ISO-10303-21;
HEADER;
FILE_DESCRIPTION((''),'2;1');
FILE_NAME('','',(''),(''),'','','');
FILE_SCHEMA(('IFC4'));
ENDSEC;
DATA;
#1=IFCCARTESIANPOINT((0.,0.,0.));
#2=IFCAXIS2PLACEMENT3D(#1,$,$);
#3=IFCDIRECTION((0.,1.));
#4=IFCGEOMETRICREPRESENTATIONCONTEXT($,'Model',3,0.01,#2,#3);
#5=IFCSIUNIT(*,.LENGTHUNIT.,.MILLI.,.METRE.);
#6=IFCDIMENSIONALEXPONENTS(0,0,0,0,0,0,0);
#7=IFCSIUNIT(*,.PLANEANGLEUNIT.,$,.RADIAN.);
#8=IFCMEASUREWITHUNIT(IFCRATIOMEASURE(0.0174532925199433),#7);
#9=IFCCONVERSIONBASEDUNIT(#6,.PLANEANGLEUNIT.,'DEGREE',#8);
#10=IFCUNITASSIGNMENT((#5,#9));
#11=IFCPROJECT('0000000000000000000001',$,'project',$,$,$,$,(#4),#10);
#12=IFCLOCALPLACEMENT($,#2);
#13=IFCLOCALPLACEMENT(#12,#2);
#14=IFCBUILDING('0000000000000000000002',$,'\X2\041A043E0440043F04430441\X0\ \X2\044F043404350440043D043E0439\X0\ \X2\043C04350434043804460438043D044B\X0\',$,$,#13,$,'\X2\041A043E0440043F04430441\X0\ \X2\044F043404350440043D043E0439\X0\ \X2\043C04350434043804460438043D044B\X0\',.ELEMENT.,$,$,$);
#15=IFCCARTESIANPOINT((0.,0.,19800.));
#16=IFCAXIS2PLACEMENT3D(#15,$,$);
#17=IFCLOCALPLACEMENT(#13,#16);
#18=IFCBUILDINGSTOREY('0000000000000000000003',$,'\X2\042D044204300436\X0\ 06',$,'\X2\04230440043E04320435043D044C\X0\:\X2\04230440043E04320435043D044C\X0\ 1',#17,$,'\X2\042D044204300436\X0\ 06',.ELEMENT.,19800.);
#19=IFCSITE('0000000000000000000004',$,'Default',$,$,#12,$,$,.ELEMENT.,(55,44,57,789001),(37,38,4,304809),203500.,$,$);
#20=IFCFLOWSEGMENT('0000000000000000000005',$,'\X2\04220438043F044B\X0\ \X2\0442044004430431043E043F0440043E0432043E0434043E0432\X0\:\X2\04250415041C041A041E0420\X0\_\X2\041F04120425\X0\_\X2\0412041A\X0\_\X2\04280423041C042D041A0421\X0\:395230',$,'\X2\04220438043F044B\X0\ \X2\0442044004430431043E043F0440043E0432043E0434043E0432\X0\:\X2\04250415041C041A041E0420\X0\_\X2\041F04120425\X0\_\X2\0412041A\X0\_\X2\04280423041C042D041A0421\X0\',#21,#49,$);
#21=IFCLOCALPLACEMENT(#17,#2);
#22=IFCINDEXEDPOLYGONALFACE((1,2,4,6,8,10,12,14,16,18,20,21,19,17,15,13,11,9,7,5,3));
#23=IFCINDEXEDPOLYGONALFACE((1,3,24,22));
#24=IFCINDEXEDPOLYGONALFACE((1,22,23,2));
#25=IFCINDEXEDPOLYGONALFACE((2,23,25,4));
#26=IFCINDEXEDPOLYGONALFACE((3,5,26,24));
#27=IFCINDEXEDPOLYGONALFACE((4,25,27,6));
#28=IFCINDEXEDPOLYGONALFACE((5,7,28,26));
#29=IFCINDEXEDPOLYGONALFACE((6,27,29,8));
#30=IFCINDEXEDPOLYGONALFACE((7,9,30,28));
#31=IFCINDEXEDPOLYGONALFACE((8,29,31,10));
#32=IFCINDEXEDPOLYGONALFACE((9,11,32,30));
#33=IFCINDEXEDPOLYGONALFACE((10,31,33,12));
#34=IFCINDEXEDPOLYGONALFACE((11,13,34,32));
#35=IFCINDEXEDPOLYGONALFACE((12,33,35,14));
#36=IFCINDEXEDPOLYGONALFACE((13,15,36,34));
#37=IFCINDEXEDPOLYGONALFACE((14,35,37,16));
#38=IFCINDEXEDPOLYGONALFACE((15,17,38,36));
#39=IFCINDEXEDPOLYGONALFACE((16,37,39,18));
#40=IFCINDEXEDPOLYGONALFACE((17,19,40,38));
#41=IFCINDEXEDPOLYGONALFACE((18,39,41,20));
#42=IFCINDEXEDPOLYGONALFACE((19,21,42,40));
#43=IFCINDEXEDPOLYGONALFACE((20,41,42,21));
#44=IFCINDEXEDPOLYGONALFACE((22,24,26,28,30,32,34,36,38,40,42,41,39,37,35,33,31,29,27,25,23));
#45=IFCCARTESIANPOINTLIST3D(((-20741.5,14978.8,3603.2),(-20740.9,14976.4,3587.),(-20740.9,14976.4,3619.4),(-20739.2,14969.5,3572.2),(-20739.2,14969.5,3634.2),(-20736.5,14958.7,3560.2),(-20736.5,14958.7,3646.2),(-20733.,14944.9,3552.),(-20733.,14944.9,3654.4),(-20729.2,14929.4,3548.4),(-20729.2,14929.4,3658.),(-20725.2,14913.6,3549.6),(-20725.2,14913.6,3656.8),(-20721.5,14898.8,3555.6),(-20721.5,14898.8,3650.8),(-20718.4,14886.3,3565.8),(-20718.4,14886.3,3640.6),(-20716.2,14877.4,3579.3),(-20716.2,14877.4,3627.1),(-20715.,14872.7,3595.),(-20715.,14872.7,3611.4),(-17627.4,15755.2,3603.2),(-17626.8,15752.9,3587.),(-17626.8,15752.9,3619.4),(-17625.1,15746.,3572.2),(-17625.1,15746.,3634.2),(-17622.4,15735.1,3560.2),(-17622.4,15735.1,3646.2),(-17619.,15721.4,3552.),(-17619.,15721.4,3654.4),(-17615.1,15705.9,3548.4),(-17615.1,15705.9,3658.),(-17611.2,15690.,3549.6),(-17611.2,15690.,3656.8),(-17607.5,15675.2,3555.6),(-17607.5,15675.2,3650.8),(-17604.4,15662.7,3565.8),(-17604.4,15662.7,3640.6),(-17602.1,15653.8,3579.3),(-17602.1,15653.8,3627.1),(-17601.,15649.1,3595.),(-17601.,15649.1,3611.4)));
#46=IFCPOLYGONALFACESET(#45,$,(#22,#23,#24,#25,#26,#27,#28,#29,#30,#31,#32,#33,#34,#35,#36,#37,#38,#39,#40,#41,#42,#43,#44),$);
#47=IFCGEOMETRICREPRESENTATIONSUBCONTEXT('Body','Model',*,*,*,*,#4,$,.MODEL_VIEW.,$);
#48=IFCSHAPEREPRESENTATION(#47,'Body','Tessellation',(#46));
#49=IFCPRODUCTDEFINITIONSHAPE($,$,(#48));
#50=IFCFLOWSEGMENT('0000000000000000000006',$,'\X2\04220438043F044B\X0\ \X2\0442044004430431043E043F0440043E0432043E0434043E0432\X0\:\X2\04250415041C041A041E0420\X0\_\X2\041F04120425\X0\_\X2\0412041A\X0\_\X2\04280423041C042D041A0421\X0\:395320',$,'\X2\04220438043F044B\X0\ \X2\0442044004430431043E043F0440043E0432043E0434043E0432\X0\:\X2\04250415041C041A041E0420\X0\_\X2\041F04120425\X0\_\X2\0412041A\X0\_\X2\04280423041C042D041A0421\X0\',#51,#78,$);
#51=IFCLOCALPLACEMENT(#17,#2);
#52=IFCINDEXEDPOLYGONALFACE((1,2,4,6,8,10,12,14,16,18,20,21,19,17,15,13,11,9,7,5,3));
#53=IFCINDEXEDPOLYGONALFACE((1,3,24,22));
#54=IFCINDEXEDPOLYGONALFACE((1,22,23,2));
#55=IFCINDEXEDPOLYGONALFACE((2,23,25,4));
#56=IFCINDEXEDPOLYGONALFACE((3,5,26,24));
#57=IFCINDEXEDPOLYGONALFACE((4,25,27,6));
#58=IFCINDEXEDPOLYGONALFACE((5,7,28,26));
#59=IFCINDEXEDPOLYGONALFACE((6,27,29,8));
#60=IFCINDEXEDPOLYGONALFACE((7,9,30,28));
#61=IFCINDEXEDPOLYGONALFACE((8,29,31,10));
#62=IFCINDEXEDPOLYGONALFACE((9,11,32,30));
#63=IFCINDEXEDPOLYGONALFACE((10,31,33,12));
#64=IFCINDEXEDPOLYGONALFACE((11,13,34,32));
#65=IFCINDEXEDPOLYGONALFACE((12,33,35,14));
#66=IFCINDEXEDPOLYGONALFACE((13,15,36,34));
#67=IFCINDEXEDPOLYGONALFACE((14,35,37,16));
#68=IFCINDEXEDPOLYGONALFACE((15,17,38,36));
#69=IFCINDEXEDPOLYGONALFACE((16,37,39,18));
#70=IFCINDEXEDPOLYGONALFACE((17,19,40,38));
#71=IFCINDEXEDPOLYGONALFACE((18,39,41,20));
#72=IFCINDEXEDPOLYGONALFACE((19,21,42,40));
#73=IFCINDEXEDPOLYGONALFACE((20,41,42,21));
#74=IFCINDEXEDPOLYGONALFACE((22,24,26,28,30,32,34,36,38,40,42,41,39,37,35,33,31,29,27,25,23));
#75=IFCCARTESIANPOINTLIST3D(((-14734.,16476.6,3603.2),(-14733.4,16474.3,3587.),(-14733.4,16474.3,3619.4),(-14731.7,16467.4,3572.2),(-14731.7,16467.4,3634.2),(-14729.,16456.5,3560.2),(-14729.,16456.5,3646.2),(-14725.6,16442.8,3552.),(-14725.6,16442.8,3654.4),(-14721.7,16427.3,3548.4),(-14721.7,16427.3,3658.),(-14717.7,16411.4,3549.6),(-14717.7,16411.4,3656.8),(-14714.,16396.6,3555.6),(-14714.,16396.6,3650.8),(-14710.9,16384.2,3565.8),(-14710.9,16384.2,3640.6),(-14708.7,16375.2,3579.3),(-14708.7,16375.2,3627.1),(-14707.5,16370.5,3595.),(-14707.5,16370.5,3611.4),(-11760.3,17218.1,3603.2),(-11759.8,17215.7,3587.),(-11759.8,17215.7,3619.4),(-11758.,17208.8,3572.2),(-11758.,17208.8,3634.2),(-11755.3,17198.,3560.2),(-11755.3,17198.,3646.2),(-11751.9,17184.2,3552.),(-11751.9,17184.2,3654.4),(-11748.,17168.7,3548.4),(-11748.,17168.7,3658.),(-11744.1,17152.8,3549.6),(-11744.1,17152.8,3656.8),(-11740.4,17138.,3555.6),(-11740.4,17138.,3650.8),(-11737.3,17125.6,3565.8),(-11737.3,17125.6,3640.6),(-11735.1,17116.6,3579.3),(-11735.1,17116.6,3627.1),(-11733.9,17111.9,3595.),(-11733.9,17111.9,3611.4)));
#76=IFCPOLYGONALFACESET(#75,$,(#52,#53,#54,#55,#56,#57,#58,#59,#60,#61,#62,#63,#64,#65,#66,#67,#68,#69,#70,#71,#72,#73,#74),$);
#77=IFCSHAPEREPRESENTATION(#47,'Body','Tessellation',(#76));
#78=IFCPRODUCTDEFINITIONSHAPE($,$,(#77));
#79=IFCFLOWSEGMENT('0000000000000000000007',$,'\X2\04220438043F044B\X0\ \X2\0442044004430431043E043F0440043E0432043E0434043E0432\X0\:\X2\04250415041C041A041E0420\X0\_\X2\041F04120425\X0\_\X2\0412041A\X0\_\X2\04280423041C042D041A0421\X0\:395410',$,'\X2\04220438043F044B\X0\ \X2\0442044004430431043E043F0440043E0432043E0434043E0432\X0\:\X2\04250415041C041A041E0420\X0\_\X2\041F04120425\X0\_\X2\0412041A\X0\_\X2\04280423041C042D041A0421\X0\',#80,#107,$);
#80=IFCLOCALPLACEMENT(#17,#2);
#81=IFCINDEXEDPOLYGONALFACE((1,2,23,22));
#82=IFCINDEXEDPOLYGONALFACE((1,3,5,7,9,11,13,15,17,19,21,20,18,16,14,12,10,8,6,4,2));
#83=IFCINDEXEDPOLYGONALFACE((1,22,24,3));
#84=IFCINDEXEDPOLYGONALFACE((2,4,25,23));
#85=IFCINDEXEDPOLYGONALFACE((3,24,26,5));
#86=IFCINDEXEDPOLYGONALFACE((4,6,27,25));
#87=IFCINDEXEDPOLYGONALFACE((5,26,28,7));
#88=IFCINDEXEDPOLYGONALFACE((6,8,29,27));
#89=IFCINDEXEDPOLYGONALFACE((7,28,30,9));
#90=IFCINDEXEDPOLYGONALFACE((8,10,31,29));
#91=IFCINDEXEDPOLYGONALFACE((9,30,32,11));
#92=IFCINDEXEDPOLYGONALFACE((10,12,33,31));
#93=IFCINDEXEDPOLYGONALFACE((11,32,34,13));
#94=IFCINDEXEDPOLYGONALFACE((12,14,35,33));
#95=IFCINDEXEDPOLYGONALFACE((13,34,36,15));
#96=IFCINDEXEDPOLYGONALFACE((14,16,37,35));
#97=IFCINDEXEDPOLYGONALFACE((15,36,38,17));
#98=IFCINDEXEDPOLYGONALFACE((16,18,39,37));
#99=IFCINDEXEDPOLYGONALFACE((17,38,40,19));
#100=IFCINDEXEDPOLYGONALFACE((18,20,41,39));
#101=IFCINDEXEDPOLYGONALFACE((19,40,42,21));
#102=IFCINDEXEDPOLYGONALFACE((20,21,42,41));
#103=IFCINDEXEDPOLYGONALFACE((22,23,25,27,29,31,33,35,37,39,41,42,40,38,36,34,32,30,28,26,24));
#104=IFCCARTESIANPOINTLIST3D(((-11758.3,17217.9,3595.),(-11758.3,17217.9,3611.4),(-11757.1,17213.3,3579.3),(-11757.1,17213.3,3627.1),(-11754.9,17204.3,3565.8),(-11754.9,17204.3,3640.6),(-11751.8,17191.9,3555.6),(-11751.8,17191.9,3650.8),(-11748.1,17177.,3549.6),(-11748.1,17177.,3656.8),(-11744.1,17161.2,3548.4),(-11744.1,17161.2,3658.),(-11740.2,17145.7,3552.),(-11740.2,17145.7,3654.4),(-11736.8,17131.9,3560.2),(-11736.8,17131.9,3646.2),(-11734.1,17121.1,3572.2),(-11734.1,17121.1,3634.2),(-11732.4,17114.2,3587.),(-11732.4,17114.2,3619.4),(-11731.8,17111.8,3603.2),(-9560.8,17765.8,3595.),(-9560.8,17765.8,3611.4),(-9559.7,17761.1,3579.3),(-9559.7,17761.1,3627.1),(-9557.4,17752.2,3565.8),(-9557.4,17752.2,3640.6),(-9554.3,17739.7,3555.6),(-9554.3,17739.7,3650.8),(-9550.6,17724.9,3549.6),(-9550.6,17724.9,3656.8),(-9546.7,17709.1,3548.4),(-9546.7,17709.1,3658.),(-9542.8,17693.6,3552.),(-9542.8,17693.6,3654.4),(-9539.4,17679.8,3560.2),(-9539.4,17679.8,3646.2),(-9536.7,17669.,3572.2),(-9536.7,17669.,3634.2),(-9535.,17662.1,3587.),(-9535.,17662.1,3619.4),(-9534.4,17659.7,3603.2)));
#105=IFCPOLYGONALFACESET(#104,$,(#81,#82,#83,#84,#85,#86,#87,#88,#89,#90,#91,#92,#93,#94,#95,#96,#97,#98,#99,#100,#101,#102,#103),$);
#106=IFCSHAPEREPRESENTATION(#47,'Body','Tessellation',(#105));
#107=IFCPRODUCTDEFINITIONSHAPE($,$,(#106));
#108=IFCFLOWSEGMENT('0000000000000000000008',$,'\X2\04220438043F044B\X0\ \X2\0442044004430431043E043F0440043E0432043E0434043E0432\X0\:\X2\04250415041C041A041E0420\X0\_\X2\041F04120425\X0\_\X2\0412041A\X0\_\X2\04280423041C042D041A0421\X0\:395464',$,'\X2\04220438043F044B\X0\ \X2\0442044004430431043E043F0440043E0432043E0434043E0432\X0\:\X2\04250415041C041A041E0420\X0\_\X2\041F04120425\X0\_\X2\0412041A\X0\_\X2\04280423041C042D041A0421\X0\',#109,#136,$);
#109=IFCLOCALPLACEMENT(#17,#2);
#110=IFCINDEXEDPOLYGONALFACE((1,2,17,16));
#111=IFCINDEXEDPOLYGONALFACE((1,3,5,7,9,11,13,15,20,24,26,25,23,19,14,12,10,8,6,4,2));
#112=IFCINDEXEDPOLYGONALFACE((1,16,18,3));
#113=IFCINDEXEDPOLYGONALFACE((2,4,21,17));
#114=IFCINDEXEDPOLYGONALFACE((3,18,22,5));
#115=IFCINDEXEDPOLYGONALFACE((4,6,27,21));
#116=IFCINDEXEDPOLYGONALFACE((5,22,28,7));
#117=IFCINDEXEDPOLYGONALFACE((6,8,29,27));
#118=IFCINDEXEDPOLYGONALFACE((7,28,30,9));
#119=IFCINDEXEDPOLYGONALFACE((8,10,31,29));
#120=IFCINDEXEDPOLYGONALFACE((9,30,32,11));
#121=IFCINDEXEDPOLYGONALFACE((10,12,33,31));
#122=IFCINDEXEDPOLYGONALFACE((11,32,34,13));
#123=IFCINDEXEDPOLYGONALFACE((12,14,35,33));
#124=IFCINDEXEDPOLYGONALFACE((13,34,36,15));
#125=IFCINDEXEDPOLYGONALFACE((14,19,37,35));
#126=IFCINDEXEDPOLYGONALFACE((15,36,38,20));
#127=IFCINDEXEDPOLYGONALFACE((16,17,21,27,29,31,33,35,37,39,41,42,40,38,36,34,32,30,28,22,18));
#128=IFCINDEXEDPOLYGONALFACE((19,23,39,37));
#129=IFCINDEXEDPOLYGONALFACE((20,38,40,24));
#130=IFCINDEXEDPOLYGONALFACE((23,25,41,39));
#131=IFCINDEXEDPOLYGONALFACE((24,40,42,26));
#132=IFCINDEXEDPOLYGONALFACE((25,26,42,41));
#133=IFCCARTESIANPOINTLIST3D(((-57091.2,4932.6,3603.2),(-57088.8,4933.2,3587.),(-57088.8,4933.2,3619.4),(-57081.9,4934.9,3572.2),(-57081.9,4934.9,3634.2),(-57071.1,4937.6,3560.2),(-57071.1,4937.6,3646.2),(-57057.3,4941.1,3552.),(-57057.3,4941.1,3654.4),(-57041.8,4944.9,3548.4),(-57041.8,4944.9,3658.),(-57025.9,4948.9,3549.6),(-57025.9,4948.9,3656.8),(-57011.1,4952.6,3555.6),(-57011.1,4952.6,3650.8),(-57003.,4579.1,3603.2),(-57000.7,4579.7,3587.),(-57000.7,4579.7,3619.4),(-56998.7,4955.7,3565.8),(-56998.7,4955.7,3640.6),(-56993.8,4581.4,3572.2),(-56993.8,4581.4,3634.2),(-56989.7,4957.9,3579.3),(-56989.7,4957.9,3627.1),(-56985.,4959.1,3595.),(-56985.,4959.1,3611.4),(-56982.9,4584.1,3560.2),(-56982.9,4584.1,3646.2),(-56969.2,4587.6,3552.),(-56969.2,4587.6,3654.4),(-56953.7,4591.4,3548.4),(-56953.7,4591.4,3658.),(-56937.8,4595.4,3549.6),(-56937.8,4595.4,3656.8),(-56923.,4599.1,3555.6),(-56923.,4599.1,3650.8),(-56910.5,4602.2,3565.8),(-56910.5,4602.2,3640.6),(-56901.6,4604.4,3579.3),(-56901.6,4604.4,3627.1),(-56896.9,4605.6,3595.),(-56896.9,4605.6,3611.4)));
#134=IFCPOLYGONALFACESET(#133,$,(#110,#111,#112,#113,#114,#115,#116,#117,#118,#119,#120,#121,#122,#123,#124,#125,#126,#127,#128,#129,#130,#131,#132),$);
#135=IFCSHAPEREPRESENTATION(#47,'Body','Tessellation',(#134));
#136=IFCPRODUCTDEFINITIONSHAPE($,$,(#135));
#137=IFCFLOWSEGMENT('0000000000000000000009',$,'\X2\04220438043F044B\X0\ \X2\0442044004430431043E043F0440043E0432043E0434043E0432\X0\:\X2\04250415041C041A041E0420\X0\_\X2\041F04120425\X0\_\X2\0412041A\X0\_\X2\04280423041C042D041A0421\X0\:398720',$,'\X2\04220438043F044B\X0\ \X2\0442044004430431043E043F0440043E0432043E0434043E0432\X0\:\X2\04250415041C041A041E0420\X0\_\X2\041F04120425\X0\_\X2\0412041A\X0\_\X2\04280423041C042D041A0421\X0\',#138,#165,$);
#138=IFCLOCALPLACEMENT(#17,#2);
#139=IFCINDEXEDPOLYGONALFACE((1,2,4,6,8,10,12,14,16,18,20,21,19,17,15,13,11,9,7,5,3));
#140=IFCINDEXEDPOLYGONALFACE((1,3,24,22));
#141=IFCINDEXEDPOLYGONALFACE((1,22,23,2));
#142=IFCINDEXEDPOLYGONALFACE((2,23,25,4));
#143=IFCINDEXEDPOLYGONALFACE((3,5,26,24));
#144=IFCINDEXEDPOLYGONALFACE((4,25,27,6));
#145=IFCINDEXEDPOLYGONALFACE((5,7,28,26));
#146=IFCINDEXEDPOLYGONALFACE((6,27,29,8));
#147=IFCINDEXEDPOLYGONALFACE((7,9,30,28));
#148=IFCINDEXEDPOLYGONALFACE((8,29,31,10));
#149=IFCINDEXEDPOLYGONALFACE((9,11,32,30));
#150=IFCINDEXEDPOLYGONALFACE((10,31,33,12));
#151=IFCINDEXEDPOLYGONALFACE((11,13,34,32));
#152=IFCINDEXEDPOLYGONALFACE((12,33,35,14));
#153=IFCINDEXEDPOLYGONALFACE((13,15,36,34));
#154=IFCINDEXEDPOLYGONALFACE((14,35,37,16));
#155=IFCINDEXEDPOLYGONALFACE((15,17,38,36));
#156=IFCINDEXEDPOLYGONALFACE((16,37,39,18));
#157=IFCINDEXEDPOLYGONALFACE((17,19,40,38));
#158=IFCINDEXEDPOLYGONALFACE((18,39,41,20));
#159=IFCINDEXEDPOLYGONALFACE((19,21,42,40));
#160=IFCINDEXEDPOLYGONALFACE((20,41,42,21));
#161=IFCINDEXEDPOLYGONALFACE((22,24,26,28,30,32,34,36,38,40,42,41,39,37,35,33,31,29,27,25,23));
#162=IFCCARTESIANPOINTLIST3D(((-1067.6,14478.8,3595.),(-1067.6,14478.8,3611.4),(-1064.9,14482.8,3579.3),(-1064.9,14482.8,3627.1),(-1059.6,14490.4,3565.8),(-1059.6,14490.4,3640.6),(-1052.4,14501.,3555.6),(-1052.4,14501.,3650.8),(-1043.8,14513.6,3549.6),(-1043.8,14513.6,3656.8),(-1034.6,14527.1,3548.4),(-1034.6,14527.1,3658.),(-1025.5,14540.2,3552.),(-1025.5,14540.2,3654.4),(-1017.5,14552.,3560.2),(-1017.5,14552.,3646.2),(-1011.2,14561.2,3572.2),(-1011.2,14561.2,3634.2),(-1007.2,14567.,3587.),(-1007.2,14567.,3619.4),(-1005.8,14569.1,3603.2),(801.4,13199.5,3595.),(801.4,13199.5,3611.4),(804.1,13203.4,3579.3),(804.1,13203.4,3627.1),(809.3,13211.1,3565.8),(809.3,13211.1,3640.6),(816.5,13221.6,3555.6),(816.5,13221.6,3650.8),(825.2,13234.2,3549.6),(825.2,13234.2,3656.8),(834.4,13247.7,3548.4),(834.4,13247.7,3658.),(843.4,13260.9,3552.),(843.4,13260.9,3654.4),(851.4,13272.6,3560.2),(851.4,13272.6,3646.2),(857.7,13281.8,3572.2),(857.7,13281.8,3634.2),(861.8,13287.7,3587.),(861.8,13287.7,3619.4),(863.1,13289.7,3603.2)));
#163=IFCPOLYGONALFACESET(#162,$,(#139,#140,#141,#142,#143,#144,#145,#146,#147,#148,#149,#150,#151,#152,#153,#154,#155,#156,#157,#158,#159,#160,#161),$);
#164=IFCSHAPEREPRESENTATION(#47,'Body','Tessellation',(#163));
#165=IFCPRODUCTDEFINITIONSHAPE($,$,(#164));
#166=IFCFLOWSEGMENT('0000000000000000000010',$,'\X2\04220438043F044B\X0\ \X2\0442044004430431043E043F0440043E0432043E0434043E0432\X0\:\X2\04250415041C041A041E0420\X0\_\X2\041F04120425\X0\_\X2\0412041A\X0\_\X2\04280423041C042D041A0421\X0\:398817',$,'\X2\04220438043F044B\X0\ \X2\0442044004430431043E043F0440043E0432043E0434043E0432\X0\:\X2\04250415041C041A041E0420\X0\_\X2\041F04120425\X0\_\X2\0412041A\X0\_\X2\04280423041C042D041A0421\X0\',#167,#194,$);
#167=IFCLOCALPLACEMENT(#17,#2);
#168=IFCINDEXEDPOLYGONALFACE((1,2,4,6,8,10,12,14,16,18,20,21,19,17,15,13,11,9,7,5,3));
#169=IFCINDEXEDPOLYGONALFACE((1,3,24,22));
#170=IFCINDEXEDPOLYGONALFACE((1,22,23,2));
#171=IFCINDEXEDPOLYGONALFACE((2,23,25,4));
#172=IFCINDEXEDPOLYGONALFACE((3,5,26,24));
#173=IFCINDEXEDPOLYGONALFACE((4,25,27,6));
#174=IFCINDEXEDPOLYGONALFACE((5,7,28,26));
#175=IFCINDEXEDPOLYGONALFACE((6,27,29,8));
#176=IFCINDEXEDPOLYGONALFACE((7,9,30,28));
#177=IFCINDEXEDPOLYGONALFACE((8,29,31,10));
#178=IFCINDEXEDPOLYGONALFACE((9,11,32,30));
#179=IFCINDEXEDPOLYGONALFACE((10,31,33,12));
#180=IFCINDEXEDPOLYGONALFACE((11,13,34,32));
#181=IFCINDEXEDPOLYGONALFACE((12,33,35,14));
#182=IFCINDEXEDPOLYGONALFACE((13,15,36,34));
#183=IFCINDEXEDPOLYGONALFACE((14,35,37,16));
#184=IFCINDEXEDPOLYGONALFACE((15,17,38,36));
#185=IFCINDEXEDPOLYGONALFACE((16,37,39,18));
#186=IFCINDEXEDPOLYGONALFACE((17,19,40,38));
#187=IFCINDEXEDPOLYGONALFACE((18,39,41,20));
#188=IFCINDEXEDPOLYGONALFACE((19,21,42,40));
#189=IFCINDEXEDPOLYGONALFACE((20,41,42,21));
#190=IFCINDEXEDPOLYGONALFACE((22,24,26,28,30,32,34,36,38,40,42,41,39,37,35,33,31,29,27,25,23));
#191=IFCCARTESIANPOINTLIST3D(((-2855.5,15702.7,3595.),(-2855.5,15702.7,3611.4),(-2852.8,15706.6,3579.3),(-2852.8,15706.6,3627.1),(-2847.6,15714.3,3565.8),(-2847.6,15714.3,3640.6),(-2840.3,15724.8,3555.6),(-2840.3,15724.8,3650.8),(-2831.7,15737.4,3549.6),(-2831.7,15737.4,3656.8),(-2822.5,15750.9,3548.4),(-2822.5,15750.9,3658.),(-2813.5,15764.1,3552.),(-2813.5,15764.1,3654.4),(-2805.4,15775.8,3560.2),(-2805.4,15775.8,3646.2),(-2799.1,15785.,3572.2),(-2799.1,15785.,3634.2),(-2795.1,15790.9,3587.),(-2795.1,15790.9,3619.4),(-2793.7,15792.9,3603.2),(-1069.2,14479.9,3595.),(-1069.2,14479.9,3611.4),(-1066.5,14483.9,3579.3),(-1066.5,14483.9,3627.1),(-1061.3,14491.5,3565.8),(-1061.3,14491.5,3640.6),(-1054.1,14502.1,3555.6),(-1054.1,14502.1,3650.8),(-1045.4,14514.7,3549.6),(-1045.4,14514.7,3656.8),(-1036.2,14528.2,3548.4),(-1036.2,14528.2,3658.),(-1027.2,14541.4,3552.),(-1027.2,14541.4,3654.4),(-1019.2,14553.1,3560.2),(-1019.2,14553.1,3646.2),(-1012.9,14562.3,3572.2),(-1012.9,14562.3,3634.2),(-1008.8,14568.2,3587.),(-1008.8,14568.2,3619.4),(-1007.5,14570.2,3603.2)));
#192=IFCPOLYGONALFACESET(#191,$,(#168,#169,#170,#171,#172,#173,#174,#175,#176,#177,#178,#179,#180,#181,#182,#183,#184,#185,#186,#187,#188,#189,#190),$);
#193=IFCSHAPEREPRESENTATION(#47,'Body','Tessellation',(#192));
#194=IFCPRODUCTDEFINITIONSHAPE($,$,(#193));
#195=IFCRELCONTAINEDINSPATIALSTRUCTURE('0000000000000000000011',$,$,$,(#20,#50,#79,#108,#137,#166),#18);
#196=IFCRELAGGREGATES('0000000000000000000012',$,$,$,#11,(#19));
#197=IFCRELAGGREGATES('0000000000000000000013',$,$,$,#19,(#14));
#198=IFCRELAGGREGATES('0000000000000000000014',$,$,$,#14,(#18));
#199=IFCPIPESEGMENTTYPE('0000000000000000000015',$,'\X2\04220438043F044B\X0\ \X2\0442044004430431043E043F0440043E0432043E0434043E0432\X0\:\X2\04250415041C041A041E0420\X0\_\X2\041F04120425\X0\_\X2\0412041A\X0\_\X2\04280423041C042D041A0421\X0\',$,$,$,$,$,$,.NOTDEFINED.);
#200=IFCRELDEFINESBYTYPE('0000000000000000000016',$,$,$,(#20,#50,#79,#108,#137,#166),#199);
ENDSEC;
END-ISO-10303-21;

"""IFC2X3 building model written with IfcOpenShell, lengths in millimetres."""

from ifc_helpers import new_model, entity, si_unit, converted_unit, direction, frame, frame_2d, origin, origin_2d_with_axis, place, context, subcontext, project, spatial, circle, extrude, type_object, element, save


model = new_model("IFC2X3")

# Units and contexts
model_context = context("Model", 3, precision=0.01, world=origin(), true_north=direction((0.0, 1.0)))
body_context = subcontext(model_context, "Body", "Model", "MODEL_VIEW")
ifc_project = project(units=[si_unit("LENGTHUNIT", "METRE", prefix="MILLI"), converted_unit("PLANEANGLEUNIT", "DEGREE", entity("IfcRatioMeasure", 0.0174532925199433), si_unit("PLANEANGLEUNIT", "RADIAN"), dimensions=[0, 0, 0, 0, 0, 0, 0])], contexts=[model_context])

# Site, building, storey
site_placement = place(None, frame((0.0, 0.0, 0.0)))
site = spatial("IfcSite", under=ifc_project, at=site_placement, Name="Default", CompositionType="ELEMENT", RefLatitude=(55, 44, 57, 789001), RefLongitude=(37, 38, 4, 304809), RefElevation=203500.0)
building_placement = place(site_placement, origin())
building = spatial("IfcBuilding", under=site, at=building_placement, Name="Корпус ядерной медицины", LongName="Корпус ядерной медицины", CompositionType="ELEMENT")
storey_placement = place(building_placement, frame((0.0, 0.0, 19800.0)))
storey = spatial("IfcBuildingStorey", under=building, at=storey_placement, Name="Этаж 06", ObjectType="Уровень:Уровень 1", LongName="Этаж 06", CompositionType="ELEMENT", Elevation=19800.0)

# Flow segments
pipe_segment_type = type_object("IfcPipeSegmentType", Name="Типы трубопроводов:ХЕМКОР_ПВХ_ВК_ШУМЭКС", PredefinedType="NOTDEFINED")
flow_segment_1_placement = place(storey_placement, frame((-20743.1, 14870.5, 3546.6)))
element("IfcFlowSegment", 1, at=flow_segment_1_placement, inside=storey, type_object=pipe_segment_type, Name="Типы трубопроводов:ХЕМКОР_ПВХ_ВК_ШУМЭКС:395230", ObjectType="Типы трубопроводов:ХЕМКОР_ПВХ_ВК_ШУМЭКС", context=body_context, shape_type="SweptSolid", body=[
    extrude(circle(Radius=55.0, at=origin_2d_with_axis()), frame((14.9, 55.0, 56.6), z_axis=(0.970296, 0.241922, 0.0), x_axis=(-0.241922, 0.970296, 0.0)), (0.0, 0.0, 1.0), 3209.4),
])
flow_segment_2_placement = place(storey_placement, frame((-14735.6, 16368.3, 3546.6)))
element("IfcFlowSegment", 2, at=flow_segment_2_placement, inside=storey, type_object=pipe_segment_type, Name="Типы трубопроводов:ХЕМКОР_ПВХ_ВК_ШУМЭКС:395320", ObjectType="Типы трубопроводов:ХЕМКОР_ПВХ_ВК_ШУМЭКС", context=body_context, shape_type="SweptSolid", body=[
    extrude(circle(Radius=55.0, at=frame_2d((0.0, 0.0), x_axis=(1.0, 0.0))), frame((14.9, 55.0, 56.6), z_axis=(0.970296, 0.241922, 0.0), x_axis=(-0.241922, 0.970296, 0.0)), (0.0, 0.0, 1.0), 3064.7),
])
flow_segment_3_placement = place(storey_placement, frame((-11760.0, 17110.2, 3546.6)))
element("IfcFlowSegment", 3, at=flow_segment_3_placement, inside=storey, type_object=pipe_segment_type, Name="Типы трубопроводов:ХЕМКОР_ПВХ_ВК_ШУМЭКС:395410", ObjectType="Типы трубопроводов:ХЕМКОР_ПВХ_ВК_ШУМЭКС", context=body_context, shape_type="SweptSolid", body=[
    extrude(circle(Radius=55.0, at=origin_2d_with_axis()), frame((14.9, 55.0, 56.6), z_axis=(0.970296, 0.241922, 0.0), x_axis=(0.241922, -0.970296, 0.0)), (0.0, 0.0, 1.0), 2264.7),
])
flow_segment_4_placement = place(storey_placement, frame((-57092.8, 4577.5, 3546.6)))
element("IfcFlowSegment", 4, at=flow_segment_4_placement, inside=storey, type_object=pipe_segment_type, Name="Типы трубопроводов:ХЕМКОР_ПВХ_ВК_ШУМЭКС:395464", ObjectType="Типы трубопроводов:ХЕМКОР_ПВХ_ВК_ШУМЭКС", context=body_context, shape_type="SweptSolid", body=[
    extrude(circle(Radius=55.0, at=origin_2d_with_axis()), frame((55.0, 368.4, 56.6), z_axis=(0.241922, -0.970296, 0.0), x_axis=(-0.970296, -0.241922, 0.0)), (0.0, 0.0, 1.0), 364.3),
])
flow_segment_5_placement = place(storey_placement, frame((-1069.5, 13197.4, 3546.6)))
element("IfcFlowSegment", 5, at=flow_segment_5_placement, inside=storey, type_object=pipe_segment_type, Name="Типы трубопроводов:ХЕМКОР_ПВХ_ВК_ШУМЭКС:398720", ObjectType="Типы трубопроводов:ХЕМКОР_ПВХ_ВК_ШУМЭКС", context=body_context, shape_type="SweptSolid", body=[
    extrude(circle(Radius=55.0, at=origin_2d_with_axis()), frame((1901.6, 47.0, 56.6), z_axis=(-0.825187, 0.564859, 0.0), x_axis=(0.564859, 0.825187, 0.0)), (0.0, 0.0, 1.0), 2264.9),
])
flow_segment_6_placement = place(storey_placement, frame((-2857.5, 14477.8, 3546.6)))
element("IfcFlowSegment", 6, at=flow_segment_6_placement, inside=storey, type_object=pipe_segment_type, Name="Типы трубопроводов:ХЕМКОР_ПВХ_ВК_ШУМЭКС:398817", ObjectType="Типы трубопроводов:ХЕМКОР_ПВХ_ВК_ШУМЭКС", context=body_context, shape_type="SweptSolid", body=[
    extrude(circle(Radius=55.0, at=origin_2d_with_axis()), frame((1818.9, 47.0, 56.6), z_axis=(-0.825187, 0.564859, 0.0), x_axis=(0.564859, 0.825187, 0.0)), (0.0, 0.0, 1.0), 2164.7),
])

save(model, "model.ifc")
